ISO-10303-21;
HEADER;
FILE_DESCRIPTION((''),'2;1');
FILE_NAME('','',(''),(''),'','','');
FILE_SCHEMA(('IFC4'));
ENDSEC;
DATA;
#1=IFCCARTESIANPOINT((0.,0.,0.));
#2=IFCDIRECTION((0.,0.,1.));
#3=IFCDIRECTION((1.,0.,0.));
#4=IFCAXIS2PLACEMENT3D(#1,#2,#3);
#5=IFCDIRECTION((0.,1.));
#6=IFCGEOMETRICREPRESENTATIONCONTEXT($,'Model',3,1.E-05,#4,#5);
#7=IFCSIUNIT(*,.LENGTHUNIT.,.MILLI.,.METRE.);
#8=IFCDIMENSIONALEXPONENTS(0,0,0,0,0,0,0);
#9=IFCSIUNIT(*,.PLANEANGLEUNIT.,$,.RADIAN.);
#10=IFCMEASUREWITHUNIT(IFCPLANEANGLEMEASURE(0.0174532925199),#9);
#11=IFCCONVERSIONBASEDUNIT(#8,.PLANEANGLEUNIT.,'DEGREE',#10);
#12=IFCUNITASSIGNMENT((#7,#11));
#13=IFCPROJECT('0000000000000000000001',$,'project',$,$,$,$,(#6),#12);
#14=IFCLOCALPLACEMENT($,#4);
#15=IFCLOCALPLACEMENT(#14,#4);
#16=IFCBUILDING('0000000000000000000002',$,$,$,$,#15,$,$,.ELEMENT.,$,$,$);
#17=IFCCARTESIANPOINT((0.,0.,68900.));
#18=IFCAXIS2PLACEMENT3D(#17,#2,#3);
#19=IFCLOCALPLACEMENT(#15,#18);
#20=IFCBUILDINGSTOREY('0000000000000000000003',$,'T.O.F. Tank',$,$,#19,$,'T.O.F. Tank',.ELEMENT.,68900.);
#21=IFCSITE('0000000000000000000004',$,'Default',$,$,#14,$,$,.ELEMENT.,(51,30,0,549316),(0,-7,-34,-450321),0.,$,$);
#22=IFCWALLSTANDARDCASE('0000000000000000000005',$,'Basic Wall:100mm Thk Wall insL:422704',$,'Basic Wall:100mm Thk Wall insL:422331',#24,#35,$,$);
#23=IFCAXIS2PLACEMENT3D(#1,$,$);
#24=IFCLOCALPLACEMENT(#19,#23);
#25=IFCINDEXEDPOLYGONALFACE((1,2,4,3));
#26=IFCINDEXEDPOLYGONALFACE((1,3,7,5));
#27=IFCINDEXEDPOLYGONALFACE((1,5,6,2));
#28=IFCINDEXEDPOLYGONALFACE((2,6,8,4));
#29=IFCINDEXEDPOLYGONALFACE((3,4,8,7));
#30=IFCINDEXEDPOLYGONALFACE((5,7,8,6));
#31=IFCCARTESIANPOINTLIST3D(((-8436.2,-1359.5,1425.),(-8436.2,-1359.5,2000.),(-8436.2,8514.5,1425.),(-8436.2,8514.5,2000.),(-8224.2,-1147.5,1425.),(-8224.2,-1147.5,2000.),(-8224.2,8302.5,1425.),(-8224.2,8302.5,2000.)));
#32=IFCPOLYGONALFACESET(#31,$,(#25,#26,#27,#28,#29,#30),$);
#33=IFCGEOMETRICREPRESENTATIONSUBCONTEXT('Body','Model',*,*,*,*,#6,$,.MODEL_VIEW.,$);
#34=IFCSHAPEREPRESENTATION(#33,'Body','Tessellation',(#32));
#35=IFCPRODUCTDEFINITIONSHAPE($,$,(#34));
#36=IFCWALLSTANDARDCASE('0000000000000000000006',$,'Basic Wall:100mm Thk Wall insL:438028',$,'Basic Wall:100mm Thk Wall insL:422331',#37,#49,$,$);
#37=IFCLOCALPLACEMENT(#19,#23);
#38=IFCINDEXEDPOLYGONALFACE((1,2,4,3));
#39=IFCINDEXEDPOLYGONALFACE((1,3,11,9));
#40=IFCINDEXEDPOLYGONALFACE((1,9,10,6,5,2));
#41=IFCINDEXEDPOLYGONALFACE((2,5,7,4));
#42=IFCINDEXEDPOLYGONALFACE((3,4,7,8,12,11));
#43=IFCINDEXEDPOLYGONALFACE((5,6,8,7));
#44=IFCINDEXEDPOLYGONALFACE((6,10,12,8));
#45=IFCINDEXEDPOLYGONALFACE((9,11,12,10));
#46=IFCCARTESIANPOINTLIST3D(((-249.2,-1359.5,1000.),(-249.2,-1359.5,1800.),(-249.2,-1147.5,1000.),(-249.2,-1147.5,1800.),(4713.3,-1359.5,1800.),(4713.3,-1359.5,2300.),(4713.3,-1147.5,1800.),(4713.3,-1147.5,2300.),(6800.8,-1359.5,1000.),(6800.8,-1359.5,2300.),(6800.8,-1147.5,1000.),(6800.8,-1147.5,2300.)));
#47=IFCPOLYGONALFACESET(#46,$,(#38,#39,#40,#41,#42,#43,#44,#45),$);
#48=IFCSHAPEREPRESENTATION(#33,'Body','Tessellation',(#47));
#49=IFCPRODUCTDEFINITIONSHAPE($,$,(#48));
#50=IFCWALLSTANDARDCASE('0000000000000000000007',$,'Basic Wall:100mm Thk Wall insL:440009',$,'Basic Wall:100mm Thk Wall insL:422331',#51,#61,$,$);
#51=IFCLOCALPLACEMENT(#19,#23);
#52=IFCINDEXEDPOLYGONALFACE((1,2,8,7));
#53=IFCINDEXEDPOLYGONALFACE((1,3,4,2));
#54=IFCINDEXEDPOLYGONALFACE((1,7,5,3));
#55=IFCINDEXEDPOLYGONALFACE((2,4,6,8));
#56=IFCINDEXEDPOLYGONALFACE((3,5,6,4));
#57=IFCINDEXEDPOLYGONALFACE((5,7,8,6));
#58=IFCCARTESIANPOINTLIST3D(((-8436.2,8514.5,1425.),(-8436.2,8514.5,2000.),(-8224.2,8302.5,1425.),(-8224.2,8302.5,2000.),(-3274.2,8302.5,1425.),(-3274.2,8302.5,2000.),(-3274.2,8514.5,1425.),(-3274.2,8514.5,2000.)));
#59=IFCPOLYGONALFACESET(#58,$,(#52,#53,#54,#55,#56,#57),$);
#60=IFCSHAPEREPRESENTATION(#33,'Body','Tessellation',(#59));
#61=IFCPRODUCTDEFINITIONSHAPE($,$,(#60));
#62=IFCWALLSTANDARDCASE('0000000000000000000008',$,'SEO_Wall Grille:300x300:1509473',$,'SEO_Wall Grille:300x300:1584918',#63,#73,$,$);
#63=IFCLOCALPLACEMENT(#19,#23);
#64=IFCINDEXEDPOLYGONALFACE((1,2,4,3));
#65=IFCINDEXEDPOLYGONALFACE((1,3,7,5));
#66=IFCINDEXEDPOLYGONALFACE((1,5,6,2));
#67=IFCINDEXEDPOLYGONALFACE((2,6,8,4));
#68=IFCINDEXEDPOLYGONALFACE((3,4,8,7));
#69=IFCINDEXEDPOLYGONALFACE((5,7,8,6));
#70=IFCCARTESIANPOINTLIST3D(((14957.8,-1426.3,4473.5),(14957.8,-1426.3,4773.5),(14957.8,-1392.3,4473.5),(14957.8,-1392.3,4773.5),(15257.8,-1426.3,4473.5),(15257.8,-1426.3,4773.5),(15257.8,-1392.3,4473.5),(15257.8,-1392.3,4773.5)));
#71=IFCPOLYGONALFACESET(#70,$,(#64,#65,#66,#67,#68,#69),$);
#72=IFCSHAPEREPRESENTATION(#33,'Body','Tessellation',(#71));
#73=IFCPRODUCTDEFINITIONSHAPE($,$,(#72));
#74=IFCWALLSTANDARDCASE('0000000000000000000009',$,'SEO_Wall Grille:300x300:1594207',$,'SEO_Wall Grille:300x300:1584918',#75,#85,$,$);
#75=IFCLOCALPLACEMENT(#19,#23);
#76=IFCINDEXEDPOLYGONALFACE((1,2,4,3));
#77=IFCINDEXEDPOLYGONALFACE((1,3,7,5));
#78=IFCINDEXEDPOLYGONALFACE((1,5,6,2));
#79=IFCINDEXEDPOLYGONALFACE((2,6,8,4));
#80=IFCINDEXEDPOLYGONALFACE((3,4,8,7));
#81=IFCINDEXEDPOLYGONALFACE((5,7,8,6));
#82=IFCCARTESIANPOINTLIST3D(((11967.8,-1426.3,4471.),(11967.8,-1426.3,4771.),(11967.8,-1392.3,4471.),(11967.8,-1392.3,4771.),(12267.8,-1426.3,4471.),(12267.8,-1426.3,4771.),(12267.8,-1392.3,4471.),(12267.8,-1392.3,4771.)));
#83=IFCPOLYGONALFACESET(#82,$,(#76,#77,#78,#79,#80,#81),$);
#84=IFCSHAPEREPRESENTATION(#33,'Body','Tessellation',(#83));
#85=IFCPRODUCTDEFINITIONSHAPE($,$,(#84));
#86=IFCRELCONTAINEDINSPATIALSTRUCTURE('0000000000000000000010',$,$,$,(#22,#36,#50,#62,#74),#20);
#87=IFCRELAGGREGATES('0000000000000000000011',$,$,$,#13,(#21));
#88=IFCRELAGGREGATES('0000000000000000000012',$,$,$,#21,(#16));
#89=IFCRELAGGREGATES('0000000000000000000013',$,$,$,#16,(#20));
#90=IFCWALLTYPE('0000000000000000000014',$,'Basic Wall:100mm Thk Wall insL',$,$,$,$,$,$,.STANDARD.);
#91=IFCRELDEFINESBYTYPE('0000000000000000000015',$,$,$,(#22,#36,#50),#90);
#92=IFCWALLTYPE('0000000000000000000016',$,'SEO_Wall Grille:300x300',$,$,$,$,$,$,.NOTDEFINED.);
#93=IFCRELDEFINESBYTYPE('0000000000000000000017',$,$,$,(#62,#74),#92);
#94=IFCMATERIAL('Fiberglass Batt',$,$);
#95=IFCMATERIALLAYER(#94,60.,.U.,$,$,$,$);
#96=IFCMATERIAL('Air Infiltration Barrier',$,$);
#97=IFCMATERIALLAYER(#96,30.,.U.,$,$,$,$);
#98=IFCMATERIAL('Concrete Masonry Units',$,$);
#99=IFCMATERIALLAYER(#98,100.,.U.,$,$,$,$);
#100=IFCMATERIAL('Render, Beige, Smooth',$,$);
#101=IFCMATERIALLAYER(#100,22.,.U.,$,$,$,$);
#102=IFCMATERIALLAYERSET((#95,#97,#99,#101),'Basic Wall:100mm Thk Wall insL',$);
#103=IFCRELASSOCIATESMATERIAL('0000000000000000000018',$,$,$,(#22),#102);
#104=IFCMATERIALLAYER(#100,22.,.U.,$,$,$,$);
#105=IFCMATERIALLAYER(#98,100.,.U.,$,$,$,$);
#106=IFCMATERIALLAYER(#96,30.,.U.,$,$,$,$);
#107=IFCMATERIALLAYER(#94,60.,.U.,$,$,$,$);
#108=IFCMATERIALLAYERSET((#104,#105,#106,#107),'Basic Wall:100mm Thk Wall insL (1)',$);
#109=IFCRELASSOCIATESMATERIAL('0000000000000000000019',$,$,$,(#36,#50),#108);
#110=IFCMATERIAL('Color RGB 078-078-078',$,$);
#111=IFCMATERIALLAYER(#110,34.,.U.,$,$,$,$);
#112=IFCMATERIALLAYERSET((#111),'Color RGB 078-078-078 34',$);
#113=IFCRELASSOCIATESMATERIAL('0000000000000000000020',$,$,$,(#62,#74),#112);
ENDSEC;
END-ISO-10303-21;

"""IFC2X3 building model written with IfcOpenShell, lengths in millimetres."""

from ifc_helpers import new_model, entity, si_unit, converted_unit, direction, frame, origin_with_axes, place, context, subcontext, project, spatial, polyline, outline, extrude, material, layer, layer_set, layer_usage, type_object, element, save


model = new_model("IFC2X3")

# Units and contexts
model_context = context("Model", 3, precision=1e-05, world=origin_with_axes(), true_north=direction((0.0, 1.0)))
body_context = subcontext(model_context, "Body", "Model", "MODEL_VIEW")
ifc_project = project(units=[si_unit("LENGTHUNIT", "METRE", prefix="MILLI"), converted_unit("PLANEANGLEUNIT", "DEGREE", entity("IfcPlaneAngleMeasure", 0.0174532925199), si_unit("PLANEANGLEUNIT", "RADIAN"), dimensions=[0, 0, 0, 0, 0, 0, 0])], contexts=[model_context])

# Site, building, storey
site_placement = place(None, origin_with_axes())
site = spatial("IfcSite", under=ifc_project, at=site_placement, Name="Default", CompositionType="ELEMENT", RefLatitude=(51, 30, 0, 549316), RefLongitude=(0, -7, -34, -450321), RefElevation=0.0)
building_placement = place(site_placement, origin_with_axes())
building = spatial("IfcBuilding", under=site, at=building_placement, CompositionType="ELEMENT")
storey_placement = place(building_placement, frame((0.0, 0.0, 68900.0), z_axis=(0.0, 0.0, 1.0), x_axis=(1.0, 0.0, 0.0)))
storey = spatial("IfcBuildingStorey", under=building, at=storey_placement, Name="T.O.F. Tank", LongName="T.O.F. Tank", CompositionType="ELEMENT", Elevation=68900.0)

# Shared definitions
ifc_material_1 = material(Name="Fiberglass Batt")
ifc_layer_1 = layer(ifc_material_1, 60.0, ventilated="UNKNOWN")
ifc_material_2 = material(Name="Air Infiltration Barrier")
ifc_layer_2 = layer(ifc_material_2, 30.0, ventilated="UNKNOWN")
ifc_material_3 = material(Name="Concrete Masonry Units")
ifc_layer_3 = layer(ifc_material_3, 100.0, ventilated="UNKNOWN")
ifc_material_4 = material(Name="Render, Beige, Smooth")
ifc_layer_4 = layer(ifc_material_4, 22.0, ventilated="UNKNOWN")
ifc_layer_set_1 = layer_set([ifc_layer_1, ifc_layer_2, ifc_layer_3, ifc_layer_4], Name="Basic Wall:100mm Thk Wall insL")
wall_type_1 = type_object("IfcWallType", Name="Basic Wall:100mm Thk Wall insL", PredefinedType="STANDARD")

# Wall
ifc_layer_usage_1 = layer_usage(ifc_layer_set_1, "AXIS2", "POSITIVE", -106.0)
wall_1_placement = place(storey_placement, frame((-8330.2, -1253.5, 1425.0), z_axis=(0.0, 0.0, 1.0), x_axis=(0.0, 1.0, 0.0)))
element("IfcWallStandardCase", 1, at=wall_1_placement, inside=storey, type_object=wall_type_1, material=ifc_layer_usage_1, Name="Basic Wall:100mm Thk Wall insL:422704", ObjectType="Basic Wall:100mm Thk Wall insL:422331", context=body_context, shape_type="SweptSolid", body=[
    extrude(outline(polyline([(106.0, -106.0), (9556.0, -106.0), (9768.0, 106.0), (-106.0, 106.0), (106.0, -106.0)])), origin_with_axes(), (0.0, 0.0, 1.0), 575.0),
])

# Wall, opening
ifc_layer_5 = layer(ifc_material_4, 22.0, ventilated="UNKNOWN")
ifc_layer_6 = layer(ifc_material_3, 100.0, ventilated="UNKNOWN")
ifc_layer_7 = layer(ifc_material_2, 30.0, ventilated="UNKNOWN")
ifc_layer_8 = layer(ifc_material_1, 60.0, ventilated="UNKNOWN")
ifc_layer_set_2 = layer_set([ifc_layer_5, ifc_layer_6, ifc_layer_7, ifc_layer_8], Name="Basic Wall:100mm Thk Wall insL (1)")
ifc_layer_usage_2 = layer_usage(ifc_layer_set_2, "AXIS2", "POSITIVE", -106.0)
wall_2_placement = place(storey_placement, frame((-249.2, -1253.5, 1000.0), z_axis=(0.0, 0.0, 1.0), x_axis=(1.0, 0.0, 0.0)))
wall_2 = element("IfcWallStandardCase", 2, at=wall_2_placement, inside=storey, type_object=wall_type_1, material=ifc_layer_usage_2, Name="Basic Wall:100mm Thk Wall insL:438028", ObjectType="Basic Wall:100mm Thk Wall insL:422331", context=body_context, shape_type="SweptSolid", body=[
    extrude(outline(polyline([(0.0, -106.0), (7050.0, -106.0), (7050.0, 106.0), (0.0, 106.0), (0.0, -106.0)])), origin_with_axes(), (0.0, 0.0, 1.0), 1300.0),
])
opening_1_placement = place(wall_2_placement, frame((2481.3, 0.0, 800.0), z_axis=(0.0, 0.0, 1.0), x_axis=(1.0, 0.0, 0.0)))
element("IfcOpeningElement", 3, at=opening_1_placement, cuts=wall_2, context=body_context, shape_type="SweptSolid", body=[
    extrude(outline(polyline([(-2481.3, 500.0), (-2481.3, 0.0), (2481.3, 0.0), (2481.3, 500.0), (-2481.3, 500.0)])), frame((0.0, 106.0, 0.0), z_axis=(0.0, -1.0, 0.0), x_axis=(1.0, 0.0, 0.0)), (0.0, 0.0, 1.0), 212.0),
])

# Walls
ifc_layer_usage_3 = layer_usage(ifc_layer_set_2, "AXIS2", "POSITIVE", -106.0)
wall_3_placement = place(storey_placement, frame((-3274.2, 8408.5, 1425.0), z_axis=(0.0, 0.0, 1.0), x_axis=(-1.0, 0.0, 0.0)))
element("IfcWallStandardCase", 4, at=wall_3_placement, inside=storey, type_object=wall_type_1, material=ifc_layer_usage_3, Name="Basic Wall:100mm Thk Wall insL:440009", ObjectType="Basic Wall:100mm Thk Wall insL:422331", context=body_context, shape_type="SweptSolid", body=[
    extrude(outline(polyline([(0.0, -106.0), (5162.0, -106.0), (4950.0, 106.0), (0.0, 106.0), (0.0, -106.0)])), origin_with_axes(), (0.0, 0.0, 1.0), 575.0),
])
ifc_material_5 = material(Name="Color RGB 078-078-078")
ifc_layer_9 = layer(ifc_material_5, 34.0, ventilated="UNKNOWN")
ifc_layer_set_3 = layer_set([ifc_layer_9], Name="Color RGB 078-078-078 34")
ifc_layer_usage_4 = layer_usage(ifc_layer_set_3, "AXIS2", "POSITIVE", 0.0)
wall_type_2 = type_object("IfcWallType", Name="SEO_Wall Grille:300x300", PredefinedType="NOTDEFINED")
wall_4_placement = place(storey_placement, frame((14957.8, -1426.3, 4473.5), z_axis=(0.0, 0.0, 1.0), x_axis=(1.0, 0.0, 0.0)))
element("IfcWallStandardCase", 5, at=wall_4_placement, inside=storey, type_object=wall_type_2, material=ifc_layer_usage_4, Name="SEO_Wall Grille:300x300:1509473", ObjectType="SEO_Wall Grille:300x300:1584918", context=body_context, shape_type="SweptSolid", body=[
    extrude(outline(polyline([(0.0, 0.0), (300.0, 0.0), (300.0, 34.0), (0.0, 34.0), (0.0, 0.0)])), origin_with_axes(), (0.0, 0.0, 1.0), 300.0),
])
ifc_layer_usage_5 = layer_usage(ifc_layer_set_3, "AXIS2", "POSITIVE", 0.0)
wall_5_placement = place(storey_placement, frame((11967.8, -1426.3, 4471.0), z_axis=(0.0, 0.0, 1.0), x_axis=(1.0, 0.0, 0.0)))
element("IfcWallStandardCase", 6, at=wall_5_placement, inside=storey, type_object=wall_type_2, material=ifc_layer_usage_5, Name="SEO_Wall Grille:300x300:1594207", ObjectType="SEO_Wall Grille:300x300:1584918", context=body_context, shape_type="SweptSolid", body=[
    extrude(outline(polyline([(0.0, 0.0), (300.0, 0.0), (300.0, 34.0), (0.0, 34.0), (0.0, 0.0)])), origin_with_axes(), (0.0, 0.0, 1.0), 300.0),
])

save(model, "model.ifc")
